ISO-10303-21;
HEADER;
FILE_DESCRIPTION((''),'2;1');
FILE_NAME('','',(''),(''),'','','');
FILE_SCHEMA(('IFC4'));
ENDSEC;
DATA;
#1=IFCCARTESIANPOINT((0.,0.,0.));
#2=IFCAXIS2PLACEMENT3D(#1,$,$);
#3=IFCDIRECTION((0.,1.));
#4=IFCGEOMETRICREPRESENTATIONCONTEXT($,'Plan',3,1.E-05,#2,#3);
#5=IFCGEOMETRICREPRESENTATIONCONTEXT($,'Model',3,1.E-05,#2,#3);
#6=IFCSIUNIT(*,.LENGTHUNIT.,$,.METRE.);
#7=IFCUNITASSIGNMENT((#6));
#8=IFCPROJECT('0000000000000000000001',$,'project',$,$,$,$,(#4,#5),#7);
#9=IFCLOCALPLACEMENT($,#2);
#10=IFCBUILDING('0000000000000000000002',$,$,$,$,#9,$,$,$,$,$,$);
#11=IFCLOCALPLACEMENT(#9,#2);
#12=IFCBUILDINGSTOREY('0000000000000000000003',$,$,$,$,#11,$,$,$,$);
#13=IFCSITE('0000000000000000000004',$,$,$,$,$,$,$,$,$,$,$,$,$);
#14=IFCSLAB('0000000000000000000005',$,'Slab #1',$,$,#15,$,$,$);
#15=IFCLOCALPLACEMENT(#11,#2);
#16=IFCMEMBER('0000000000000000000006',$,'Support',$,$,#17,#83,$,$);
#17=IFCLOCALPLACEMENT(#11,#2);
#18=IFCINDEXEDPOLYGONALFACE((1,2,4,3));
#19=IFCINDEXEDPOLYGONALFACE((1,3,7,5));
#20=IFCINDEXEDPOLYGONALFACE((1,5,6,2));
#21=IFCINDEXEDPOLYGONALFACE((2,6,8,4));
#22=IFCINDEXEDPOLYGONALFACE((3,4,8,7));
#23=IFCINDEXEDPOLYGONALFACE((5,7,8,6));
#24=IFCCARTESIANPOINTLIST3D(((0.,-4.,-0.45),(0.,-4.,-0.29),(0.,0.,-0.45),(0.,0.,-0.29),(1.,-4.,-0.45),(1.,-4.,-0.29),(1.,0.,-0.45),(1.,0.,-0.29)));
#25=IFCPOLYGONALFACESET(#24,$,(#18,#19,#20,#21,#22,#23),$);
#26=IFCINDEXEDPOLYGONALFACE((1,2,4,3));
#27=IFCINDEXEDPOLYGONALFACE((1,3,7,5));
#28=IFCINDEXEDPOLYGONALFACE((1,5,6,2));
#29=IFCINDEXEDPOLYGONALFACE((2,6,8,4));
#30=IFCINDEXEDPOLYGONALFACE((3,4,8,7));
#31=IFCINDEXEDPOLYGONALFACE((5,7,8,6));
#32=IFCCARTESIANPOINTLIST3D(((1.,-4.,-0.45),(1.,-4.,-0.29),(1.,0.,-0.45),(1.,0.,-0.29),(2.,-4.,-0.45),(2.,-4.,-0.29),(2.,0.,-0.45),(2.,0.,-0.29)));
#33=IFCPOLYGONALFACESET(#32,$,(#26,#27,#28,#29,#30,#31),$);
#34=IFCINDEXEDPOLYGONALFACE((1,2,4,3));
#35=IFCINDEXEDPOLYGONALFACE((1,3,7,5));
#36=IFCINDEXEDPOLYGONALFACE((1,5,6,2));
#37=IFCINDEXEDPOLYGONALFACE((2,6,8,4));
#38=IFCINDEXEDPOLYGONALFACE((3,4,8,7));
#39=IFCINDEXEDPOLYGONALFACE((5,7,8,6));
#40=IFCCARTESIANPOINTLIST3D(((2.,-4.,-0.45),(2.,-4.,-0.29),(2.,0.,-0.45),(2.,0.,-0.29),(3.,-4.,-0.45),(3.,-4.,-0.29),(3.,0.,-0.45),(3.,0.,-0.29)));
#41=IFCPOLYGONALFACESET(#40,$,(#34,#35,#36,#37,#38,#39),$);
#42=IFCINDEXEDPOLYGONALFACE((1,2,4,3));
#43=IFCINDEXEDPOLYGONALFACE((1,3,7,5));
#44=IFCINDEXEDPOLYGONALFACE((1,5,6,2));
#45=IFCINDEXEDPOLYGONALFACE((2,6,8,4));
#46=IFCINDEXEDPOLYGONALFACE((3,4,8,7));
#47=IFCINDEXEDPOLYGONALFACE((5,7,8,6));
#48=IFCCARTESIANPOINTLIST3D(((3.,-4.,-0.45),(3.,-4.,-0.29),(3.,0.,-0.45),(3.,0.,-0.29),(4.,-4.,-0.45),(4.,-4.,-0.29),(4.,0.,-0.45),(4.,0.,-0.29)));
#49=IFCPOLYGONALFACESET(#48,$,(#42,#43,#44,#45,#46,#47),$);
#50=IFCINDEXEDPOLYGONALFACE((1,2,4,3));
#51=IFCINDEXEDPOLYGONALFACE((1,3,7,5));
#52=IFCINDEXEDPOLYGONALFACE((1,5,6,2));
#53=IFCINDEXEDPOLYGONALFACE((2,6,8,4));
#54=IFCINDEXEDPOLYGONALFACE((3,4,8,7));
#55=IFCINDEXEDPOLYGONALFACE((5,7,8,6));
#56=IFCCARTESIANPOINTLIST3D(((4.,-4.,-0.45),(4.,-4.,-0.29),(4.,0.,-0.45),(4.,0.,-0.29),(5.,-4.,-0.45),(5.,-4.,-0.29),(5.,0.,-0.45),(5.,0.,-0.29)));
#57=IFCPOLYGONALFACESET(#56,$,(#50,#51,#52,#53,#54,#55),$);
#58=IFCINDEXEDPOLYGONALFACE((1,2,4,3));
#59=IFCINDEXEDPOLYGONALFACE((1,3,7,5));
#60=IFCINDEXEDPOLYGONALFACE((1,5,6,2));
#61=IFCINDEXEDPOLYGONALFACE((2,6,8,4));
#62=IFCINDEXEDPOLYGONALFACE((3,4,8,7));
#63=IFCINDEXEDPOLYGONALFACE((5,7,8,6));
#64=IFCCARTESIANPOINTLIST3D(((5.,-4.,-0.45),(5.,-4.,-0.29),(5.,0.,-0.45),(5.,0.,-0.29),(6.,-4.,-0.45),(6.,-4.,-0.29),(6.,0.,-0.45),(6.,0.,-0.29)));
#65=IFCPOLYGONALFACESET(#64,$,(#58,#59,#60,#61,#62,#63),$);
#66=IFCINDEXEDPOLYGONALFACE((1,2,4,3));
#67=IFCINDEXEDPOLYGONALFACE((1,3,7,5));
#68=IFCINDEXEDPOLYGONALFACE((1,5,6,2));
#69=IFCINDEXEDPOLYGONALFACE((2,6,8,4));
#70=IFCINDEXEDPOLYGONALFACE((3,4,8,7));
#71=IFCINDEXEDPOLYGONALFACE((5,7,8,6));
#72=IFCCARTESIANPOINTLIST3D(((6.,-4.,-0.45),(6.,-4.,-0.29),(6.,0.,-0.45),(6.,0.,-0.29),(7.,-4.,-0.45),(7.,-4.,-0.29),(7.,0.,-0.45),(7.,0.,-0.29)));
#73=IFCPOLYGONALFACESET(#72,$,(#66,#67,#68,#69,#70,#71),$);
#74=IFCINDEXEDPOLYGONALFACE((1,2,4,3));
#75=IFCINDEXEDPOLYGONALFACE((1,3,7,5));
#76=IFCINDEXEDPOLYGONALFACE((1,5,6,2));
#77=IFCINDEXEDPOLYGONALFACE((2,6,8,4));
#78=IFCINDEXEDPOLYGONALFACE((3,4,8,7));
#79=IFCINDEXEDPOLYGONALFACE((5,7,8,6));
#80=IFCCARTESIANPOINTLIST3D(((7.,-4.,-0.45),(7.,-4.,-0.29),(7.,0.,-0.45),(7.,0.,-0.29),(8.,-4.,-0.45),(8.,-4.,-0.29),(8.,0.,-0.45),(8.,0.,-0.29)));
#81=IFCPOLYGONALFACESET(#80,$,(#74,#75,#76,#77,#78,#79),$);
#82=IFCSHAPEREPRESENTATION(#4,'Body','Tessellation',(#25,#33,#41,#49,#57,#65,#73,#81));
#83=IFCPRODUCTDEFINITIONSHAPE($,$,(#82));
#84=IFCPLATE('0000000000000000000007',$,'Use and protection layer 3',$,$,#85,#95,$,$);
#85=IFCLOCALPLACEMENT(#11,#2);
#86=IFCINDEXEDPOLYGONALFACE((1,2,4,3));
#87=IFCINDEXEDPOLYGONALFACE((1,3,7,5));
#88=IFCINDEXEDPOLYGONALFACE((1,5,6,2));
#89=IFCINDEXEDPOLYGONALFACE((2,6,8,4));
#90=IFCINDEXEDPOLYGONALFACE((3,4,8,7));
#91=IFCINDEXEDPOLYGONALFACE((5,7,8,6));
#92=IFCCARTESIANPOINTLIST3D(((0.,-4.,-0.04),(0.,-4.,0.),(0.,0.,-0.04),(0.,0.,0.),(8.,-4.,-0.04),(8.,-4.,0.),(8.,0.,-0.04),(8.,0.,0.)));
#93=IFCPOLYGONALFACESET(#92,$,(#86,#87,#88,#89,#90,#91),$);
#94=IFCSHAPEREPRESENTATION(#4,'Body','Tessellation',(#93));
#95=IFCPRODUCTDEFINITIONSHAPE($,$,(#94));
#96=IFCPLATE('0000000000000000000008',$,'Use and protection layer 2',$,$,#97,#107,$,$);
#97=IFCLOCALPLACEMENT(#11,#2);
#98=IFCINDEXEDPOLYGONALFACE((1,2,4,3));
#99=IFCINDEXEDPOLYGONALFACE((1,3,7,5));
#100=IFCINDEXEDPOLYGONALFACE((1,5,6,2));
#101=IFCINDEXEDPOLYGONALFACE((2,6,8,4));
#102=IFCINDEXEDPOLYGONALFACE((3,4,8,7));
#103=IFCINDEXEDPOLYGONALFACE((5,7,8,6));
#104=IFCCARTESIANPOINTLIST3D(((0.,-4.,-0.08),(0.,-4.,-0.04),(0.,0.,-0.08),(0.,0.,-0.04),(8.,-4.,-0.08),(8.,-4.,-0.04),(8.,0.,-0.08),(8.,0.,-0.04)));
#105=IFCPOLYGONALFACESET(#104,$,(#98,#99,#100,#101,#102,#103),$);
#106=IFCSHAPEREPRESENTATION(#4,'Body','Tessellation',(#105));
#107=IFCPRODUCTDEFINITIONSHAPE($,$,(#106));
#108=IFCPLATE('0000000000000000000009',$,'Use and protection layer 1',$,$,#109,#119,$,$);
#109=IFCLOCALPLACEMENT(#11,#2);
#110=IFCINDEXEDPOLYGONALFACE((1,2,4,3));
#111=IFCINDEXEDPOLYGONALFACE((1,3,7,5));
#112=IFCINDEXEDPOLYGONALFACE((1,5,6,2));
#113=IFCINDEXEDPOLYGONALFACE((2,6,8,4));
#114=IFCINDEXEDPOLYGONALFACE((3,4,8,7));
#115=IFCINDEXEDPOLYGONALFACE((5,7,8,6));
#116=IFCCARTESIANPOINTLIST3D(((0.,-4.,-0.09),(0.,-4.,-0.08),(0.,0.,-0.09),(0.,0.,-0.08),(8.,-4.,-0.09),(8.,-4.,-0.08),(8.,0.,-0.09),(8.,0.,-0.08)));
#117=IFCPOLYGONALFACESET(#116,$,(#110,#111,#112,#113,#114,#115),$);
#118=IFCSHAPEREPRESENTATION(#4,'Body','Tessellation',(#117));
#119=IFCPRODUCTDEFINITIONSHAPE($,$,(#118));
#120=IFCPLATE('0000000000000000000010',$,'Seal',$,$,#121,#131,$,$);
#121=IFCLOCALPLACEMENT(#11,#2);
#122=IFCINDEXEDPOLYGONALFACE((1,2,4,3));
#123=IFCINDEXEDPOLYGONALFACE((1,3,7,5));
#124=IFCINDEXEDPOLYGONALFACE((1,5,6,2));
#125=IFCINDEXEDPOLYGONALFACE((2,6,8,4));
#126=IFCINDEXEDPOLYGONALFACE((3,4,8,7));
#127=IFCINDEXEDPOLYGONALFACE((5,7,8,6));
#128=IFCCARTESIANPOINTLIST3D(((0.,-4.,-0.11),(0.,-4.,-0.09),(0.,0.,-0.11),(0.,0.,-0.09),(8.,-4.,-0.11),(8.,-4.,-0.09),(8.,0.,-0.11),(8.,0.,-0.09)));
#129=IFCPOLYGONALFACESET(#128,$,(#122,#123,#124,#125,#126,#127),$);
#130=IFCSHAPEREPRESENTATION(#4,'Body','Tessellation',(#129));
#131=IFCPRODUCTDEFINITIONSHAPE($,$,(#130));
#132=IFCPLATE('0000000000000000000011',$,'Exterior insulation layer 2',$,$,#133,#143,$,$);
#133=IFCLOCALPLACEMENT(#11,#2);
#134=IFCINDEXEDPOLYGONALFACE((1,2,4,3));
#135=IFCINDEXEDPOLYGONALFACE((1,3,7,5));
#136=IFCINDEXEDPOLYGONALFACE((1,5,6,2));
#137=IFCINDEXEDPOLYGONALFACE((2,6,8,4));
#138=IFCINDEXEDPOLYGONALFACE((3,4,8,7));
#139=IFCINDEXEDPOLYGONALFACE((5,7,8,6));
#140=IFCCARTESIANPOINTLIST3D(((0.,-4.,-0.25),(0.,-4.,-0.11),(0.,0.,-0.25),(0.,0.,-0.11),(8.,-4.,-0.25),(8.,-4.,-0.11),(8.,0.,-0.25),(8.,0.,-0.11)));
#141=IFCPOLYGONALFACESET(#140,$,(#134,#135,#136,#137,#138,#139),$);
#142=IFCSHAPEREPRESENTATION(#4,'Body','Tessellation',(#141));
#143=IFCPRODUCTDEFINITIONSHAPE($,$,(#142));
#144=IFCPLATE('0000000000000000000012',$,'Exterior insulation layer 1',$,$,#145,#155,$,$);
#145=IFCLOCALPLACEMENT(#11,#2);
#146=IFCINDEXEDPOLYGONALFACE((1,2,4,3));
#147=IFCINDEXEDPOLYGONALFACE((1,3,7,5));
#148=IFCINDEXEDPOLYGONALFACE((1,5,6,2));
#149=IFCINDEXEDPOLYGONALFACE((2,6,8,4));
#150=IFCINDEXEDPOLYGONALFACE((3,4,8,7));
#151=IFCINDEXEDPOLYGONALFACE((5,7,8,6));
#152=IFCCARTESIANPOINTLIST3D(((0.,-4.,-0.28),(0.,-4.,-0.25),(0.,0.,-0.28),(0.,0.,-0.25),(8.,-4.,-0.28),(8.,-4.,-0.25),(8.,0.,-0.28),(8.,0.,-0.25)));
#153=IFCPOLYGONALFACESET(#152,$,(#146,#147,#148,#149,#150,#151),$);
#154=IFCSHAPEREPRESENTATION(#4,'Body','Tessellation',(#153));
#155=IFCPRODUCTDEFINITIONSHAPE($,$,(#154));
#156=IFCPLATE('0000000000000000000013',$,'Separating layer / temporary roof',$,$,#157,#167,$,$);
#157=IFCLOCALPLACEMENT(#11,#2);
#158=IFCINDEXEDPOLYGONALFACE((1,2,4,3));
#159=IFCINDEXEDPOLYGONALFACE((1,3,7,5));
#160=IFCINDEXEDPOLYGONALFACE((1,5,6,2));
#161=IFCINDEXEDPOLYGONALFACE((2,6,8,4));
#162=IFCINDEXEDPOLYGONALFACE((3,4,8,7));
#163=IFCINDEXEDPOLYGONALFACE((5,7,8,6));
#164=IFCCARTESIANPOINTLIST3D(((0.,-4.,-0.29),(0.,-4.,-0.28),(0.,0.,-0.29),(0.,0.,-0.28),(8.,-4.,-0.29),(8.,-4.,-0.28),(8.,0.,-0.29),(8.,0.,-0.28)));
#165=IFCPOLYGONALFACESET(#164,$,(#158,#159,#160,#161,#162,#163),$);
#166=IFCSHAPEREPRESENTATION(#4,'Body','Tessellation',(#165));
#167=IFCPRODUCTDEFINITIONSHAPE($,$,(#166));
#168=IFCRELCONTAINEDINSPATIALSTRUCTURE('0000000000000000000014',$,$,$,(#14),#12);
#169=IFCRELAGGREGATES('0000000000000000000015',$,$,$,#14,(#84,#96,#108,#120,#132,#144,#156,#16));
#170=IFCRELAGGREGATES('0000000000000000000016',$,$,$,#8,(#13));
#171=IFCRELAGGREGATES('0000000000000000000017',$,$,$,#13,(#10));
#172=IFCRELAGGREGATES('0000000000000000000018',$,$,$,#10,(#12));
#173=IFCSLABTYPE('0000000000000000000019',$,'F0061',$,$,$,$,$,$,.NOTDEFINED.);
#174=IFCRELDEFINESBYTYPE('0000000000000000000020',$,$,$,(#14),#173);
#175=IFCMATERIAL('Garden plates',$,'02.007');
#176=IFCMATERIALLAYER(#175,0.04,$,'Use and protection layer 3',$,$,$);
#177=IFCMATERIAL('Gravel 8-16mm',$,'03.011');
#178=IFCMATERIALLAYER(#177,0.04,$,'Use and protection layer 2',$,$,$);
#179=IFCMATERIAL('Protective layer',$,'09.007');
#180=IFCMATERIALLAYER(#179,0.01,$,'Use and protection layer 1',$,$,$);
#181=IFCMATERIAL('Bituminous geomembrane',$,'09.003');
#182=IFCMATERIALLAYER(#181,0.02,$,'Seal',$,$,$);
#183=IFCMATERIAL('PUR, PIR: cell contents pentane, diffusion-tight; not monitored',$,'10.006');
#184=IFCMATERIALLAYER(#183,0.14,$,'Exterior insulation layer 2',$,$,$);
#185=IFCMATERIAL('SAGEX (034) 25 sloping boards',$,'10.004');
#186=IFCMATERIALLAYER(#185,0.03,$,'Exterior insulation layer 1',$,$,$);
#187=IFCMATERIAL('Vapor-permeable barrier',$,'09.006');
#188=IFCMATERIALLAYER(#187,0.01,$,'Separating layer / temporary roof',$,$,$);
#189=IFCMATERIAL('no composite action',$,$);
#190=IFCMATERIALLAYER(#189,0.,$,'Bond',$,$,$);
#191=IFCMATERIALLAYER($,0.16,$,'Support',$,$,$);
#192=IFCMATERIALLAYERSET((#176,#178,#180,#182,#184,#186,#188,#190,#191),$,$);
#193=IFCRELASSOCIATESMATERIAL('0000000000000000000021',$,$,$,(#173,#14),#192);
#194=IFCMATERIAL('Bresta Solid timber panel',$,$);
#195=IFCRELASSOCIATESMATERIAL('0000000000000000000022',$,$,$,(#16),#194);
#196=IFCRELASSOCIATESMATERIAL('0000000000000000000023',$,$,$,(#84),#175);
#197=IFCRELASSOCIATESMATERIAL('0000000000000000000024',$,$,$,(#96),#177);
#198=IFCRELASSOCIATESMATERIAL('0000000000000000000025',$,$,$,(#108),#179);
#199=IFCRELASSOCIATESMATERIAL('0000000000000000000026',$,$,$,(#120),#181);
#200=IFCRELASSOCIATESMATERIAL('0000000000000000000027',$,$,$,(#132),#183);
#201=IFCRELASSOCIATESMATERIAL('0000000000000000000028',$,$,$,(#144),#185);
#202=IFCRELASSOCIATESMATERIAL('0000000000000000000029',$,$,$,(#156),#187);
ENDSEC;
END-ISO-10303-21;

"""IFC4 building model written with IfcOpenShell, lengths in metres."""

from ifc_helpers import new_model, si_unit, direction, frame, frame_2d, origin, origin_with_axes, place, context, project, spatial, rectangle, extrude, material, layer, layer_set, type_object, element, aggregate, save


model = new_model("IFC4")

# Units and contexts
plan_context = context("Plan", 3, precision=1e-05, world=origin(), true_north=direction((0.0, 1.0)))
model_context = context("Model", 3, precision=1e-05, world=origin(), true_north=direction((0.0, 1.0)))
ifc_project = project(units=[si_unit("LENGTHUNIT", "METRE")], contexts=[plan_context, model_context])

# Site, building, storey
site = spatial("IfcSite", under=ifc_project)
building_placement = place(None, origin())
building = spatial("IfcBuilding", under=site, at=building_placement)
storey_placement = place(building_placement, origin())
storey = spatial("IfcBuildingStorey", under=building, at=storey_placement)

# Slab, member, plates
ifc_material_1 = material(Name="Garden plates", Category="02.007")
ifc_layer_1 = layer(ifc_material_1, 0.04, Name="Use and protection layer 3")
ifc_material_2 = material(Name="Gravel 8-16mm", Category="03.011")
ifc_layer_2 = layer(ifc_material_2, 0.04, Name="Use and protection layer 2")
ifc_material_3 = material(Name="Protective layer", Category="09.007")
ifc_layer_3 = layer(ifc_material_3, 0.01, Name="Use and protection layer 1")
ifc_material_4 = material(Name="Bituminous geomembrane", Category="09.003")
ifc_layer_4 = layer(ifc_material_4, 0.02, Name="Seal")
ifc_material_5 = material(Name="PUR, PIR: cell contents pentane, diffusion-tight; not monitored", Category="10.006")
ifc_layer_5 = layer(ifc_material_5, 0.14, Name="Exterior insulation layer 2")
ifc_material_6 = material(Name="SAGEX (034) 25 sloping boards", Category="10.004")
ifc_layer_6 = layer(ifc_material_6, 0.03, Name="Exterior insulation layer 1")
ifc_material_7 = material(Name="Vapor-permeable barrier", Category="09.006")
ifc_layer_7 = layer(ifc_material_7, 0.01, Name="Separating layer / temporary roof")
ifc_material_8 = material(Name="no composite action")
ifc_layer_8 = layer(ifc_material_8, 0.0, Name="Bond")
ifc_layer_9 = layer(None, 0.16, Name="Support")
ifc_layer_set = layer_set([ifc_layer_1, ifc_layer_2, ifc_layer_3, ifc_layer_4, ifc_layer_5, ifc_layer_6, ifc_layer_7, ifc_layer_8, ifc_layer_9])
slab_type = type_object("IfcSlabType", Name="F0061", PredefinedType="NOTDEFINED", material=ifc_layer_set)
slab_placement = place(None, frame((0.0, 0.0, 0.0), z_axis=(0.0, 0.0, -1.0), x_axis=(1.0, 0.0, 0.0)))
slab = element("IfcSlab", 1, at=slab_placement, inside=storey, type_object=slab_type, material=ifc_layer_set, Name="Slab #1")
ifc_material_9 = material(Name="Bresta Solid timber panel")
member_placement = place(slab_placement, origin())
member = element("IfcMember", 2, at=member_placement, material=ifc_material_9, Name="Support", context=plan_context, shape_type="SweptSolid", body=[
    extrude(rectangle(XDim=1.0, YDim=0.16, at=frame_2d((0.5, 0.08), x_axis=(1.0, 0.0))), frame((0.0, 4.0, 0.29), z_axis=(0.0, -1.0, 0.0), x_axis=(1.0, 0.0, 0.0)), (0.0, 0.0, 1.0), 4.0),
    extrude(rectangle(XDim=1.0, YDim=0.16, at=frame_2d((0.5, 0.08), x_axis=(1.0, 0.0))), frame((1.0, 4.0, 0.29), z_axis=(0.0, -1.0, 0.0), x_axis=(1.0, 0.0, 0.0)), (0.0, 0.0, 1.0), 4.0),
    extrude(rectangle(XDim=1.0, YDim=0.16, at=frame_2d((0.5, 0.08), x_axis=(1.0, 0.0))), frame((2.0, 4.0, 0.29), z_axis=(0.0, -1.0, 0.0), x_axis=(1.0, 0.0, 0.0)), (0.0, 0.0, 1.0), 4.0),
    extrude(rectangle(XDim=1.0, YDim=0.16, at=frame_2d((0.5, 0.08), x_axis=(1.0, 0.0))), frame((3.0, 4.0, 0.29), z_axis=(0.0, -1.0, 0.0), x_axis=(1.0, 0.0, 0.0)), (0.0, 0.0, 1.0), 4.0),
    extrude(rectangle(XDim=1.0, YDim=0.16, at=frame_2d((0.5, 0.08), x_axis=(1.0, 0.0))), frame((4.0, 4.0, 0.29), z_axis=(0.0, -1.0, 0.0), x_axis=(1.0, 0.0, 0.0)), (0.0, 0.0, 1.0), 4.0),
    extrude(rectangle(XDim=1.0, YDim=0.16, at=frame_2d((0.5, 0.08), x_axis=(1.0, 0.0))), frame((5.0, 4.0, 0.29), z_axis=(0.0, -1.0, 0.0), x_axis=(1.0, 0.0, 0.0)), (0.0, 0.0, 1.0), 4.0),
    extrude(rectangle(XDim=1.0, YDim=0.16, at=frame_2d((0.5, 0.08), x_axis=(1.0, 0.0))), frame((6.0, 4.0, 0.29), z_axis=(0.0, -1.0, 0.0), x_axis=(1.0, 0.0, 0.0)), (0.0, 0.0, 1.0), 4.0),
    extrude(rectangle(XDim=1.0, YDim=0.16, at=frame_2d((0.5, 0.08), x_axis=(1.0, 0.0))), frame((7.0, 4.0, 0.29), z_axis=(0.0, -1.0, 0.0), x_axis=(1.0, 0.0, 0.0)), (0.0, 0.0, 1.0), 4.0),
])
plate_1_placement = place(slab_placement, origin())
plate_1 = element("IfcPlate", 3, at=plate_1_placement, material=ifc_material_1, Name="Use and protection layer 3", context=plan_context, shape_type="SweptSolid", body=[
    extrude(rectangle(XDim=8.0, YDim=4.0, at=frame_2d((4.0, 2.0), x_axis=(1.0, 0.0))), origin_with_axes(), (0.0, 0.0, 1.0), 0.04),
])
plate_2_placement = place(slab_placement, origin())
plate_2 = element("IfcPlate", 4, at=plate_2_placement, material=ifc_material_2, Name="Use and protection layer 2", context=plan_context, shape_type="SweptSolid", body=[
    extrude(rectangle(XDim=8.0, YDim=4.0, at=frame_2d((4.0, 2.0), x_axis=(1.0, 0.0))), frame((0.0, 0.0, 0.04), z_axis=(0.0, 0.0, 1.0), x_axis=(1.0, 0.0, 0.0)), (0.0, 0.0, 1.0), 0.04),
])
plate_3_placement = place(slab_placement, origin())
plate_3 = element("IfcPlate", 5, at=plate_3_placement, material=ifc_material_3, Name="Use and protection layer 1", context=plan_context, shape_type="SweptSolid", body=[
    extrude(rectangle(XDim=8.0, YDim=4.0, at=frame_2d((4.0, 2.0), x_axis=(1.0, 0.0))), frame((0.0, 0.0, 0.08), z_axis=(0.0, 0.0, 1.0), x_axis=(1.0, 0.0, 0.0)), (0.0, 0.0, 1.0), 0.01),
])
plate_4_placement = place(slab_placement, origin())
plate_4 = element("IfcPlate", 6, at=plate_4_placement, material=ifc_material_4, Name="Seal", context=plan_context, shape_type="SweptSolid", body=[
    extrude(rectangle(XDim=8.0, YDim=4.0, at=frame_2d((4.0, 2.0), x_axis=(1.0, 0.0))), frame((0.0, 0.0, 0.09), z_axis=(0.0, 0.0, 1.0), x_axis=(1.0, 0.0, 0.0)), (0.0, 0.0, 1.0), 0.02),
])
plate_5_placement = place(slab_placement, origin())
plate_5 = element("IfcPlate", 7, at=plate_5_placement, material=ifc_material_5, Name="Exterior insulation layer 2", context=plan_context, shape_type="SweptSolid", body=[
    extrude(rectangle(XDim=8.0, YDim=4.0, at=frame_2d((4.0, 2.0), x_axis=(1.0, 0.0))), frame((0.0, 0.0, 0.11), z_axis=(0.0, 0.0, 1.0), x_axis=(1.0, 0.0, 0.0)), (0.0, 0.0, 1.0), 0.14),
])
plate_6_placement = place(slab_placement, origin())
plate_6 = element("IfcPlate", 8, at=plate_6_placement, material=ifc_material_6, Name="Exterior insulation layer 1", context=plan_context, shape_type="SweptSolid", body=[
    extrude(rectangle(XDim=8.0, YDim=4.0, at=frame_2d((4.0, 2.0), x_axis=(1.0, 0.0))), frame((0.0, 0.0, 0.25), z_axis=(0.0, 0.0, 1.0), x_axis=(1.0, 0.0, 0.0)), (0.0, 0.0, 1.0), 0.03),
])
plate_7_placement = place(slab_placement, origin())
plate_7 = element("IfcPlate", 9, at=plate_7_placement, material=ifc_material_7, Name="Separating layer / temporary roof", context=plan_context, shape_type="SweptSolid", body=[
    extrude(rectangle(XDim=8.0, YDim=4.0, at=frame_2d((4.0, 2.0), x_axis=(1.0, 0.0))), frame((0.0, 0.0, 0.28), z_axis=(0.0, 0.0, 1.0), x_axis=(1.0, 0.0, 0.0)), (0.0, 0.0, 1.0), 0.01),
])
aggregate(slab, [plate_1, plate_2, plate_3, plate_4, plate_5, plate_6, plate_7, member])

save(model, "model.ifc")
